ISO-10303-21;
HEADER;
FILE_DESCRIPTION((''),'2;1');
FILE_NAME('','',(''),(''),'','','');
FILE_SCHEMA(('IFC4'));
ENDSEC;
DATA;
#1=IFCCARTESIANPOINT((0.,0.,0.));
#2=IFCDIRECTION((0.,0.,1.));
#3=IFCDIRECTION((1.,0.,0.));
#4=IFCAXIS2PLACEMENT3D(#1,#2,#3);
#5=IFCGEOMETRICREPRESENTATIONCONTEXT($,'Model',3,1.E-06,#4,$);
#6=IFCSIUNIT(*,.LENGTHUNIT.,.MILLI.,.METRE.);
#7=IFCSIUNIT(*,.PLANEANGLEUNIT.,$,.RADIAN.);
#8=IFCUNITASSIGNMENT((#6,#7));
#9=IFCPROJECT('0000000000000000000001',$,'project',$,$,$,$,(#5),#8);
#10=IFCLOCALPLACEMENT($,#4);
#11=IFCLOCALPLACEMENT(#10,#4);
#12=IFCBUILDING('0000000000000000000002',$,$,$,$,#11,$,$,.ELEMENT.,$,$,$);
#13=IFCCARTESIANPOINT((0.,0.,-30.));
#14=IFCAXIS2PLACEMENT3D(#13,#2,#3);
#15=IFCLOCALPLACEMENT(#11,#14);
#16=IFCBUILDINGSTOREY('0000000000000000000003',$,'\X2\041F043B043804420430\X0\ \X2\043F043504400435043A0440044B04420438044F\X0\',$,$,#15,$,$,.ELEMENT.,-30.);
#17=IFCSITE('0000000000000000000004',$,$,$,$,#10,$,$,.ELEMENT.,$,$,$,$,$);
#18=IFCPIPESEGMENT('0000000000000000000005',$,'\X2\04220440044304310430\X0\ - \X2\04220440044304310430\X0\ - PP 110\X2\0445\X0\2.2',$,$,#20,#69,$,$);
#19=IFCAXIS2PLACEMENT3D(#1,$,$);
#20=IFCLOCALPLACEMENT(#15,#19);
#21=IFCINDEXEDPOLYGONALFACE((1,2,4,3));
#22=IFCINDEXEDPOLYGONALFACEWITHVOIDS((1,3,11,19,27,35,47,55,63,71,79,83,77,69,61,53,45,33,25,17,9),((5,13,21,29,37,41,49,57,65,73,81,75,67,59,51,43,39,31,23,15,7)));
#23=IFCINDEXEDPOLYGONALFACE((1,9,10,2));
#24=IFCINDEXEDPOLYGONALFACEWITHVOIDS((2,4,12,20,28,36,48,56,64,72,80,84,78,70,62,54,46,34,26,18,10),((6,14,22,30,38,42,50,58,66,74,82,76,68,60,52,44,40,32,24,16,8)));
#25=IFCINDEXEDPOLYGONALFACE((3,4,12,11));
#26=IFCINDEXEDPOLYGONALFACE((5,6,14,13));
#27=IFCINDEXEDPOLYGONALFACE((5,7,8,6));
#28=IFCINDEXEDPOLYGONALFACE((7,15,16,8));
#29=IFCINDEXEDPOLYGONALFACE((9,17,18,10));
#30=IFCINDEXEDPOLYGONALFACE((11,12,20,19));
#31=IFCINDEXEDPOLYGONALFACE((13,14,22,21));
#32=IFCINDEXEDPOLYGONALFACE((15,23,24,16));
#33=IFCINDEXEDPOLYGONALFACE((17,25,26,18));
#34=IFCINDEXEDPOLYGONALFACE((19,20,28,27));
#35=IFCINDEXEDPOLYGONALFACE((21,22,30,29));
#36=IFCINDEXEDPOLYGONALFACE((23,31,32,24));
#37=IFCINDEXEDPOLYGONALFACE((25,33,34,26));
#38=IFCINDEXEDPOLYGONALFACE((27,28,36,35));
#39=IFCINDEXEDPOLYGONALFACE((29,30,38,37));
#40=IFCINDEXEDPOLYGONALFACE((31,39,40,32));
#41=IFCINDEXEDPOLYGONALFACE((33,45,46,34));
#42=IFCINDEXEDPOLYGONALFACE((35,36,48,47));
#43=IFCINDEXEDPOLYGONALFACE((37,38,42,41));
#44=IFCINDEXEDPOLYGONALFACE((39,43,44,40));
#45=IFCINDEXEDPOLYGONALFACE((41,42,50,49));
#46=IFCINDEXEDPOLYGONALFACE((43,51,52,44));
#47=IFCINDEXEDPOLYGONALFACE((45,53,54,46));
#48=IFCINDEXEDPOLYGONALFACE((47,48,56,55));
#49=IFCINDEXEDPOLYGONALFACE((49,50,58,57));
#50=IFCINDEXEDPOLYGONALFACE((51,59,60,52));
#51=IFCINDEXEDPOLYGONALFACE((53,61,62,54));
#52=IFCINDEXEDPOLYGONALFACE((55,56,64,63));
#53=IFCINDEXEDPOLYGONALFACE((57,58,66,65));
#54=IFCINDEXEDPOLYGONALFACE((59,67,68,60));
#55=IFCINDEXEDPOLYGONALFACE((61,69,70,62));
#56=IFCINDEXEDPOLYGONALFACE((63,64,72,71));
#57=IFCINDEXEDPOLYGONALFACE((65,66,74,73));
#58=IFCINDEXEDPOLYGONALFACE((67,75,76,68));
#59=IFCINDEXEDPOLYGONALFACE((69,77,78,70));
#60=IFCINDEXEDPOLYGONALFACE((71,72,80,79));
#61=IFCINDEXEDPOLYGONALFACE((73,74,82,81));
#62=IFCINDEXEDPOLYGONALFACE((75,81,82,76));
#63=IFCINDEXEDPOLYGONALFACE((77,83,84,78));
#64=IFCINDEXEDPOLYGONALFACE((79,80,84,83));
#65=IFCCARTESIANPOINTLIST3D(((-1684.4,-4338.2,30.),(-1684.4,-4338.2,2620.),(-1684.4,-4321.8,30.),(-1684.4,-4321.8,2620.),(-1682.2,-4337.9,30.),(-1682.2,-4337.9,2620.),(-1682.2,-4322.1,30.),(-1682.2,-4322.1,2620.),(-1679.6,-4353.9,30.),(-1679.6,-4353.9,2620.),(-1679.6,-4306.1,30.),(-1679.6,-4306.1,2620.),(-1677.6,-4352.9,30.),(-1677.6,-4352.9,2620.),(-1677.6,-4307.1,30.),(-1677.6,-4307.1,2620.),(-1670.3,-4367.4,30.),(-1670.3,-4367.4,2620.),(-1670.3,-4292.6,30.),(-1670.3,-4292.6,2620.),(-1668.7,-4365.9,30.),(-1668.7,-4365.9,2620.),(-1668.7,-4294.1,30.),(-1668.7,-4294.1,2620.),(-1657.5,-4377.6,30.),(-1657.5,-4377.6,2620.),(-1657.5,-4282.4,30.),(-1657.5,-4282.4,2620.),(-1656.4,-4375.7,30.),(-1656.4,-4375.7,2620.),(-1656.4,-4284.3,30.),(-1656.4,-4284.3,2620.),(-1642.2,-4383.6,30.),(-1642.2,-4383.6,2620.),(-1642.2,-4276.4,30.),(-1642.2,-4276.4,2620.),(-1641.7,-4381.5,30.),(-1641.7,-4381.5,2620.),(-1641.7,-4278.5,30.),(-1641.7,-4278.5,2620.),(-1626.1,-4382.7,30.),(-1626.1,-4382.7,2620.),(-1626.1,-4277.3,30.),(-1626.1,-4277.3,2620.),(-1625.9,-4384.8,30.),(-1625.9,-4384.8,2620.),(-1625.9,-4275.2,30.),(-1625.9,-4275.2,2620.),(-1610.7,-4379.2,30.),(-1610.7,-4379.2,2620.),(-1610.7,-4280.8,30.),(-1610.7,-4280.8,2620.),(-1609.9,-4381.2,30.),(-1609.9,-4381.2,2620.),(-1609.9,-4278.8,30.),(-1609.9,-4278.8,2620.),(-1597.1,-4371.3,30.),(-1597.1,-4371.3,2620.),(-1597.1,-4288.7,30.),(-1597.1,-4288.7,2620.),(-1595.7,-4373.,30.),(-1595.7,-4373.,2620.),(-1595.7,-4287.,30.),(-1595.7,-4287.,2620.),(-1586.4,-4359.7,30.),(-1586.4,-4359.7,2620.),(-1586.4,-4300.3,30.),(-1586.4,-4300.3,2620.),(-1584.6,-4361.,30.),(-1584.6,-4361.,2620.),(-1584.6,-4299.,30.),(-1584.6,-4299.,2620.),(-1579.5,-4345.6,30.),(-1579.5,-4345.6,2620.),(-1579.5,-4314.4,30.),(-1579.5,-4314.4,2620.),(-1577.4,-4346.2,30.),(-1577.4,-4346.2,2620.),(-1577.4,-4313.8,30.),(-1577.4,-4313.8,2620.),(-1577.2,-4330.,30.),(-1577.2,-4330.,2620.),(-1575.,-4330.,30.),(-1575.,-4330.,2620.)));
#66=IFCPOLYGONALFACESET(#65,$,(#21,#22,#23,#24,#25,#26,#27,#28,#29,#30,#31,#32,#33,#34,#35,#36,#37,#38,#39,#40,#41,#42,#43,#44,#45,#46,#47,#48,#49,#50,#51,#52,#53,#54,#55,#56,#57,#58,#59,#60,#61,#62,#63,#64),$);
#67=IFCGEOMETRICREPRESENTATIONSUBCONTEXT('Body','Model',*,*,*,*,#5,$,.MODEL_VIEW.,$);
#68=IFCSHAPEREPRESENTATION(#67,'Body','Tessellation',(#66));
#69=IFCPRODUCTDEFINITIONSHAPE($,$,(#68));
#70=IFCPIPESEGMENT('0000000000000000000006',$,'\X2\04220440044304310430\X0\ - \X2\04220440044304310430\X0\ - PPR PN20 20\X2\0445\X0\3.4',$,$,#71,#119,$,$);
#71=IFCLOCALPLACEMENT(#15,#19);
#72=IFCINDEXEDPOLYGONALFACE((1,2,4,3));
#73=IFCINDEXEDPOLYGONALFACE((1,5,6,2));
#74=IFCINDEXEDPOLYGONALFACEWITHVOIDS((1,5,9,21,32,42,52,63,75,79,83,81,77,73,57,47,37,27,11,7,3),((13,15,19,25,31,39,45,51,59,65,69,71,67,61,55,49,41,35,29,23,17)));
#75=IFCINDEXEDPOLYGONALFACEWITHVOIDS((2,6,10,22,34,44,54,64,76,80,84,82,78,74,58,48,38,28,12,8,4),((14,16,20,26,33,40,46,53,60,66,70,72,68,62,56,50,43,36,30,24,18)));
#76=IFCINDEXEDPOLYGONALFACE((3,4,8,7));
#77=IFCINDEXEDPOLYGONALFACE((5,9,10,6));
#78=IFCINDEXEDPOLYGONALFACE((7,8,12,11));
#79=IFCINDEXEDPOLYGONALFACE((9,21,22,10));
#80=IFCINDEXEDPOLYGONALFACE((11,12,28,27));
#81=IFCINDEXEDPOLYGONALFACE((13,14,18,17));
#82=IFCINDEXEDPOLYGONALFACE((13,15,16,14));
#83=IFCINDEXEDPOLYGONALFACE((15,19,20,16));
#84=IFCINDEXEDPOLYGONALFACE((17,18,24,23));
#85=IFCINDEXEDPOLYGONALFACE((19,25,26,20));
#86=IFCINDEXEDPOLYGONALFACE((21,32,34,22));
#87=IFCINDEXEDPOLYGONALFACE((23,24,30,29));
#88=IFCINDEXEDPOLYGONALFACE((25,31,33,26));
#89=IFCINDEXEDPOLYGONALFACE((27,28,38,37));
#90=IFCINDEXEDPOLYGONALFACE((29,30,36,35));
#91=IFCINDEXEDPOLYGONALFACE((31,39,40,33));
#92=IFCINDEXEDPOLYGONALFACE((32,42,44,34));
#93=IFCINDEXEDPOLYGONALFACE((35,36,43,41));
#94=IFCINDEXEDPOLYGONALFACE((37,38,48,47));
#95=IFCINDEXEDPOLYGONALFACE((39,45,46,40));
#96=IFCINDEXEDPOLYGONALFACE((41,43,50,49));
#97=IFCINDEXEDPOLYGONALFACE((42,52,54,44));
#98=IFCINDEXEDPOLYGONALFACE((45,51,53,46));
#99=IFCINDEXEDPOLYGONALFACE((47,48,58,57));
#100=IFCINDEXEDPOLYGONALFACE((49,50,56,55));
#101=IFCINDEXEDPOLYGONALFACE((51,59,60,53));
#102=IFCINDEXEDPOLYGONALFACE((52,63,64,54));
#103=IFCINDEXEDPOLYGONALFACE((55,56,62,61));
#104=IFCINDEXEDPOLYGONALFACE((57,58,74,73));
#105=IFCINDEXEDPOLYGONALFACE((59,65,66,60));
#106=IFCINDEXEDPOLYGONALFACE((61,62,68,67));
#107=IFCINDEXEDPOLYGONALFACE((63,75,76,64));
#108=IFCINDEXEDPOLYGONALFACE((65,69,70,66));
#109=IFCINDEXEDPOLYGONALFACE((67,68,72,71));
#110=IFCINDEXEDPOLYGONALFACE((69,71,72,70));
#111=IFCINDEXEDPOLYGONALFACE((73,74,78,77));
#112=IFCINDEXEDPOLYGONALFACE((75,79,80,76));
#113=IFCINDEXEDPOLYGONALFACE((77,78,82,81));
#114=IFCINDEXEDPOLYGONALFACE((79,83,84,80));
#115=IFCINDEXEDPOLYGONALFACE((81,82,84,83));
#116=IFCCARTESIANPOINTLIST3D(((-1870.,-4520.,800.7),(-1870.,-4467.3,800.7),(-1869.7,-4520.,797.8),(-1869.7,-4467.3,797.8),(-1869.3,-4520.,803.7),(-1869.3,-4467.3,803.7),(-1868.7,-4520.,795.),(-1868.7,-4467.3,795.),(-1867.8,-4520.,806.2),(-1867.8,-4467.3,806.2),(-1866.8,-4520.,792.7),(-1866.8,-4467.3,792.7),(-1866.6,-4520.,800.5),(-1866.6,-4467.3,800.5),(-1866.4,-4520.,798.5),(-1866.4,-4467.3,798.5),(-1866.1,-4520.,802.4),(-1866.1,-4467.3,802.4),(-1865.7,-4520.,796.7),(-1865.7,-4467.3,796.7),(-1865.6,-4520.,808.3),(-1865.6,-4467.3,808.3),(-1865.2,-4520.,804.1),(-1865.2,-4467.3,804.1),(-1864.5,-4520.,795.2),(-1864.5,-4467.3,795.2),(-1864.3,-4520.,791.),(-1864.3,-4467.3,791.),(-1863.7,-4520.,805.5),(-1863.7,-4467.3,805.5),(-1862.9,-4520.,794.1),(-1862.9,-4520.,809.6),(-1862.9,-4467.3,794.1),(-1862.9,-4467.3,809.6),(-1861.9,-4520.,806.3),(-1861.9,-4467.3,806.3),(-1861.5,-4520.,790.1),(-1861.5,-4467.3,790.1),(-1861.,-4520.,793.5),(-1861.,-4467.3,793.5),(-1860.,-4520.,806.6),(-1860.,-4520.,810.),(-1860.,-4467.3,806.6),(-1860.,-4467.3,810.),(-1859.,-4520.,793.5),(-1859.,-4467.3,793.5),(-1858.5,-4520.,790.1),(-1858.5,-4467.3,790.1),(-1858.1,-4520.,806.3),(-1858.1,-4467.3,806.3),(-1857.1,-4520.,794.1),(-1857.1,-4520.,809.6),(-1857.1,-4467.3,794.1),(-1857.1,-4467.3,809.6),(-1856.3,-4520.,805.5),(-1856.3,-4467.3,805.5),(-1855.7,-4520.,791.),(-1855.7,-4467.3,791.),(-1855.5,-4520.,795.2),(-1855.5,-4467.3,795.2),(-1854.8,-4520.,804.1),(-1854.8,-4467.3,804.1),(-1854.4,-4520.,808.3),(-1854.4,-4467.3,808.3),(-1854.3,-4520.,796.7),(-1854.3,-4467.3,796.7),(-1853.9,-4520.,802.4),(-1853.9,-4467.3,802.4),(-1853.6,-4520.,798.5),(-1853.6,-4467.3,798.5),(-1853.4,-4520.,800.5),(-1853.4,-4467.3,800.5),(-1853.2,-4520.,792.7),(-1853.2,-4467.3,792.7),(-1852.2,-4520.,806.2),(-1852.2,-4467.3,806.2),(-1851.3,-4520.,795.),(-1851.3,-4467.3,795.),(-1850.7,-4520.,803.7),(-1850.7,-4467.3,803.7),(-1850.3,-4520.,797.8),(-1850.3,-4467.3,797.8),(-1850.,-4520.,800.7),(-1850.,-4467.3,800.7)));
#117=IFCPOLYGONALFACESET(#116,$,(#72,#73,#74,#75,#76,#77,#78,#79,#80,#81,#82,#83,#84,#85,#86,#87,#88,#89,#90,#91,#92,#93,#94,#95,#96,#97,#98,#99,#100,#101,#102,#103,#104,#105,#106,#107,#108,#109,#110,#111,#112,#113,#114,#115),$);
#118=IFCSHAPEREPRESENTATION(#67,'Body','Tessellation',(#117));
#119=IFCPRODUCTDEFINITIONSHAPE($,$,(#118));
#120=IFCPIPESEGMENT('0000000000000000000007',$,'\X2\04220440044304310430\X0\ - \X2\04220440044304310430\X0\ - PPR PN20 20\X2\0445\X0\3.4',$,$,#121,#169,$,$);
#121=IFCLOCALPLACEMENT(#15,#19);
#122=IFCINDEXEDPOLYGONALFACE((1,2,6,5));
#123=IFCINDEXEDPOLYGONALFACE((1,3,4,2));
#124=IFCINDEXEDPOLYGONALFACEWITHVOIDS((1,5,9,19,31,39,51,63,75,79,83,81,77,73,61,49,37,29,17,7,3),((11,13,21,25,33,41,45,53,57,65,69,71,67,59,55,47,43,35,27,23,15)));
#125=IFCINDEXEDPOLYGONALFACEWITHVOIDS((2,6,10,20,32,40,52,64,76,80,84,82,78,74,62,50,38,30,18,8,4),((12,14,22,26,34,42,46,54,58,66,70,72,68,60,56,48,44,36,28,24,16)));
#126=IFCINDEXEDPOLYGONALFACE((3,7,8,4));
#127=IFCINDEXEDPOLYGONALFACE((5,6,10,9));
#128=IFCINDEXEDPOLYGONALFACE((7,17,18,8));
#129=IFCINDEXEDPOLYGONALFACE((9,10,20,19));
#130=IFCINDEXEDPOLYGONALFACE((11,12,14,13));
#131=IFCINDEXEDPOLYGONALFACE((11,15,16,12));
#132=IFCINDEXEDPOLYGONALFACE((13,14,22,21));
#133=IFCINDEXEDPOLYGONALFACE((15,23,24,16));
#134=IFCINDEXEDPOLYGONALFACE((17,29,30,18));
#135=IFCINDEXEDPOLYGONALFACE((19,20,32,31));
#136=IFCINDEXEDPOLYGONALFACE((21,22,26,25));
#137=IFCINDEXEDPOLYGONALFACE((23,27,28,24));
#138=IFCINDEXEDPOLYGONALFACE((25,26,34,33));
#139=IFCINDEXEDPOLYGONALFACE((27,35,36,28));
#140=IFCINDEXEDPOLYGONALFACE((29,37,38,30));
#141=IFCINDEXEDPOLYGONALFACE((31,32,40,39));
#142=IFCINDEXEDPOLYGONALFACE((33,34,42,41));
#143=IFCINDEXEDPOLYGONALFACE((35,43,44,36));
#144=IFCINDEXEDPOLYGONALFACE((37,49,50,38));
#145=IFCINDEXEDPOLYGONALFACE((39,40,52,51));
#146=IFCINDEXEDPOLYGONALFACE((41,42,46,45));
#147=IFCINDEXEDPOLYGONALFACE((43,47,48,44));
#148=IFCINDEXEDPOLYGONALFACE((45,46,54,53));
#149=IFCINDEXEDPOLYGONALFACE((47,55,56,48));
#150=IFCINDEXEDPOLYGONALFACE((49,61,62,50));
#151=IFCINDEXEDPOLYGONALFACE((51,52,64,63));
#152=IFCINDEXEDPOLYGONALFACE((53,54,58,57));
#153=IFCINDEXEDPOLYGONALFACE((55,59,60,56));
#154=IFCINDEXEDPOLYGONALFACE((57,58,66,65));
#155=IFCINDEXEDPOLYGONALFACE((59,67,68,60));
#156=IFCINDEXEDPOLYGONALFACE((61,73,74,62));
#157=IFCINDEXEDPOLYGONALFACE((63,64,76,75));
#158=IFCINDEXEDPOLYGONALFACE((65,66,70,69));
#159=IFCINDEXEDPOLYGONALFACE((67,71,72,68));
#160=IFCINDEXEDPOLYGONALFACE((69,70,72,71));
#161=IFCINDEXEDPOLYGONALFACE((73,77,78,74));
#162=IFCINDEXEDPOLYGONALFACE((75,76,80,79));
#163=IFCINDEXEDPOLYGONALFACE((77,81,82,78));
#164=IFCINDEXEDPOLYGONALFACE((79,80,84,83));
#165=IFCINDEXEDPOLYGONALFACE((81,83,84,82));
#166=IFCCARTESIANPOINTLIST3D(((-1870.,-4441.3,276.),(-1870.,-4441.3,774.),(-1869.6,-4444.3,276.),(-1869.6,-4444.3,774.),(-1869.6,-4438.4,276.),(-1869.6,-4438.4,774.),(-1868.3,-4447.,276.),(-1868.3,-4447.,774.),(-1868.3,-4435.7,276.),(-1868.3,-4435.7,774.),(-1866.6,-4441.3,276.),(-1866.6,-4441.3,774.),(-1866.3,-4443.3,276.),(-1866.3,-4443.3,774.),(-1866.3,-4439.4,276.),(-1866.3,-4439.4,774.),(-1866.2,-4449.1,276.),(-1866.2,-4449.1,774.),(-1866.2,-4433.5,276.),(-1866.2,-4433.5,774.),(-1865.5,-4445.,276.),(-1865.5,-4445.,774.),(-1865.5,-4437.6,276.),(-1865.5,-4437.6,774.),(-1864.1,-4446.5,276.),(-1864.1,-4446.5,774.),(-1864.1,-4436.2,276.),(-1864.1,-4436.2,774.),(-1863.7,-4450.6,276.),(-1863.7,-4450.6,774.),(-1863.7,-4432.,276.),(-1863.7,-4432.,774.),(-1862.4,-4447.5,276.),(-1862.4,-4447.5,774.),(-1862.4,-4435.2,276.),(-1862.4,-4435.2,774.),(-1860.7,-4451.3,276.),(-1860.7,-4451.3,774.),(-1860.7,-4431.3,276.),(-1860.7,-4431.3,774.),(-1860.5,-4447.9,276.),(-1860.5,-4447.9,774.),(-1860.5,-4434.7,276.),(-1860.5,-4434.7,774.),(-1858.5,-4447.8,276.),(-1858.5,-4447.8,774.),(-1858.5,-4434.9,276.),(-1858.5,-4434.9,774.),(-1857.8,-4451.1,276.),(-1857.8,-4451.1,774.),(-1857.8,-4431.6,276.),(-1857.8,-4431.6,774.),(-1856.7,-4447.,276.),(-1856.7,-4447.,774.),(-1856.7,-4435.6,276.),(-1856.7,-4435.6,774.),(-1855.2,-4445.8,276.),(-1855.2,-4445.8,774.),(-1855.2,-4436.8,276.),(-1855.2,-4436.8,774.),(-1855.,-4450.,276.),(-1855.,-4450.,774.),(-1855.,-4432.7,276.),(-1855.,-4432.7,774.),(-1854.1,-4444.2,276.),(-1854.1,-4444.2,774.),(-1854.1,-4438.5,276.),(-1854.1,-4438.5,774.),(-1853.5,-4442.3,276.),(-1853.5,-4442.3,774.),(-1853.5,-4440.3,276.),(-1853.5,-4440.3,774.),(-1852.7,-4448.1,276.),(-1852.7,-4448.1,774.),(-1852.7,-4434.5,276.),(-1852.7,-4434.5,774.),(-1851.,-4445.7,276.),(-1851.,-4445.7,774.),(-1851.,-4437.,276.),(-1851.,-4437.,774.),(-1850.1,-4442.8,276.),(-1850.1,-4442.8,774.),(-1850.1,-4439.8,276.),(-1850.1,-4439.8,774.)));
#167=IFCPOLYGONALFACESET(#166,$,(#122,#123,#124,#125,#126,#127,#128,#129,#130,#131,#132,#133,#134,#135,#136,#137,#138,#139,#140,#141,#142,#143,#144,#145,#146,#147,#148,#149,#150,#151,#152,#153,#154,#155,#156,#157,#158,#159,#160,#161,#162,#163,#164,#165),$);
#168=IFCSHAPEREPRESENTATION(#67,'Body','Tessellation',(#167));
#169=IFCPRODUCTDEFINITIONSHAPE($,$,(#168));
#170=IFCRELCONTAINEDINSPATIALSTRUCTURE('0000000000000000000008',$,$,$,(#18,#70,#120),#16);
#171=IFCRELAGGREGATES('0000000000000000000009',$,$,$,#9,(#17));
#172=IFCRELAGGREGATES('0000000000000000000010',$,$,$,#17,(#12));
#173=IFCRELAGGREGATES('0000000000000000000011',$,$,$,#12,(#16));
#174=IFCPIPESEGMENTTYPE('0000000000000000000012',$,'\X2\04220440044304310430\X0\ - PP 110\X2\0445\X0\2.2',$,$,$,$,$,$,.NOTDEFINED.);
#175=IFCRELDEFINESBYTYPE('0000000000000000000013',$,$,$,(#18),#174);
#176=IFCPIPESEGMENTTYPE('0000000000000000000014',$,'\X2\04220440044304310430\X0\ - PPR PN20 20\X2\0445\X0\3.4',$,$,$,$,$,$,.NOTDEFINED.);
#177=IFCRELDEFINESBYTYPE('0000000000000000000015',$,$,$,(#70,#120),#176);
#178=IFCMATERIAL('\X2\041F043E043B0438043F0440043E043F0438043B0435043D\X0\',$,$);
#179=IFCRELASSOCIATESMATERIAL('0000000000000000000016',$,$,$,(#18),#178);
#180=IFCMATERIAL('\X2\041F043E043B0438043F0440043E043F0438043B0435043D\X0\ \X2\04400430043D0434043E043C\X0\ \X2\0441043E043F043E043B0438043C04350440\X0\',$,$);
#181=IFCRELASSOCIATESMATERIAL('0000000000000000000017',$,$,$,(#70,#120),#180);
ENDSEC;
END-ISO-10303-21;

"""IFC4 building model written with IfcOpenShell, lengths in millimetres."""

from ifc_helpers import new_model, entity, si_unit, frame, origin_with_axes, place, context, subcontext, project, spatial, material, type_object, element, save


model = new_model("IFC4")

# Units and contexts
model_context = context("Model", 3, precision=1e-06, world=origin_with_axes())
body_context = subcontext(model_context, "Body", "Model", "MODEL_VIEW")
ifc_project = project(units=[si_unit("LENGTHUNIT", "METRE", prefix="MILLI"), si_unit("PLANEANGLEUNIT", "RADIAN")], contexts=[model_context])

# Site, building, storey
site_placement = place(None, origin_with_axes())
site = spatial("IfcSite", under=ifc_project, at=site_placement, CompositionType="ELEMENT")
building_placement = place(site_placement, origin_with_axes())
building = spatial("IfcBuilding", under=site, at=building_placement, CompositionType="ELEMENT")
storey_placement = place(building_placement, frame((0.0, 0.0, -30.0), z_axis=(0.0, 0.0, 1.0), x_axis=(1.0, 0.0, 0.0)))
storey = spatial("IfcBuildingStorey", under=building, at=storey_placement, Name="Плита перекрытия", CompositionType="ELEMENT", Elevation=-30.0)

# Pipe segments
ifc_material_1 = material(Name="Полипропилен")
pipe_segment_type_1 = type_object("IfcPipeSegmentType", Name="Труба - PP 110х2.2", PredefinedType="NOTDEFINED")
pipe_segment_1_placement = place(storey_placement, frame((-1630.0, -4330.0, 2620.0), z_axis=(0.0, 0.0, 1.0), x_axis=(-1.0, 0.0, 0.0)))
element("IfcPipeSegment", 1, at=pipe_segment_1_placement, inside=storey, type_object=pipe_segment_type_1, material=ifc_material_1, Name="Труба - Труба - PP 110х2.2", context=body_context, shape_type="AdvancedSweptSolid", body=[
    entity("IfcSweptDiskSolid", entity("IfcIndexedPolyCurve", entity("IfcCartesianPointList3D", [[0.0, 0.0, 0.0], [0.0, 0.0, -2590.0]]), [entity("IfcLineIndex", [1, 2])]), 55.0, 52.8),
])
ifc_material_2 = material(Name="Полипропилен рандом сополимер")
pipe_segment_type_2 = type_object("IfcPipeSegmentType", Name="Труба - PPR PN20 20х3.4", PredefinedType="NOTDEFINED")
pipe_segment_2_placement = place(storey_placement, frame((-1860.0, -4520.0, 800.0), z_axis=(0.0, 0.0, 1.0), x_axis=(0.0, 1.0, 0.0)))
element("IfcPipeSegment", 2, at=pipe_segment_2_placement, inside=storey, type_object=pipe_segment_type_2, material=ifc_material_2, Name="Труба - Труба - PPR PN20 20х3.4", context=body_context, shape_type="AdvancedSweptSolid", body=[
    entity("IfcSweptDiskSolid", entity("IfcIndexedPolyCurve", entity("IfcCartesianPointList3D", [[0.0, 0.0, 0.0], [52.7, 0.0, 0.0]]), [entity("IfcLineIndex", [1, 2])]), 10.0, 6.6),
])
pipe_segment_3_placement = place(storey_placement, frame((-1860.0, -4441.3, 774.0), z_axis=(0.0, 0.0, 1.0), x_axis=(1.0, 0.0, 0.0)))
element("IfcPipeSegment", 3, at=pipe_segment_3_placement, inside=storey, type_object=pipe_segment_type_2, material=ifc_material_2, Name="Труба - Труба - PPR PN20 20х3.4", context=body_context, shape_type="AdvancedSweptSolid", body=[
    entity("IfcSweptDiskSolid", entity("IfcIndexedPolyCurve", entity("IfcCartesianPointList3D", [[0.0, 0.0, 0.0], [0.0, 0.0, -498.0]]), [entity("IfcLineIndex", [1, 2])]), 10.0, 6.6),
])

save(model, "model.ifc")
